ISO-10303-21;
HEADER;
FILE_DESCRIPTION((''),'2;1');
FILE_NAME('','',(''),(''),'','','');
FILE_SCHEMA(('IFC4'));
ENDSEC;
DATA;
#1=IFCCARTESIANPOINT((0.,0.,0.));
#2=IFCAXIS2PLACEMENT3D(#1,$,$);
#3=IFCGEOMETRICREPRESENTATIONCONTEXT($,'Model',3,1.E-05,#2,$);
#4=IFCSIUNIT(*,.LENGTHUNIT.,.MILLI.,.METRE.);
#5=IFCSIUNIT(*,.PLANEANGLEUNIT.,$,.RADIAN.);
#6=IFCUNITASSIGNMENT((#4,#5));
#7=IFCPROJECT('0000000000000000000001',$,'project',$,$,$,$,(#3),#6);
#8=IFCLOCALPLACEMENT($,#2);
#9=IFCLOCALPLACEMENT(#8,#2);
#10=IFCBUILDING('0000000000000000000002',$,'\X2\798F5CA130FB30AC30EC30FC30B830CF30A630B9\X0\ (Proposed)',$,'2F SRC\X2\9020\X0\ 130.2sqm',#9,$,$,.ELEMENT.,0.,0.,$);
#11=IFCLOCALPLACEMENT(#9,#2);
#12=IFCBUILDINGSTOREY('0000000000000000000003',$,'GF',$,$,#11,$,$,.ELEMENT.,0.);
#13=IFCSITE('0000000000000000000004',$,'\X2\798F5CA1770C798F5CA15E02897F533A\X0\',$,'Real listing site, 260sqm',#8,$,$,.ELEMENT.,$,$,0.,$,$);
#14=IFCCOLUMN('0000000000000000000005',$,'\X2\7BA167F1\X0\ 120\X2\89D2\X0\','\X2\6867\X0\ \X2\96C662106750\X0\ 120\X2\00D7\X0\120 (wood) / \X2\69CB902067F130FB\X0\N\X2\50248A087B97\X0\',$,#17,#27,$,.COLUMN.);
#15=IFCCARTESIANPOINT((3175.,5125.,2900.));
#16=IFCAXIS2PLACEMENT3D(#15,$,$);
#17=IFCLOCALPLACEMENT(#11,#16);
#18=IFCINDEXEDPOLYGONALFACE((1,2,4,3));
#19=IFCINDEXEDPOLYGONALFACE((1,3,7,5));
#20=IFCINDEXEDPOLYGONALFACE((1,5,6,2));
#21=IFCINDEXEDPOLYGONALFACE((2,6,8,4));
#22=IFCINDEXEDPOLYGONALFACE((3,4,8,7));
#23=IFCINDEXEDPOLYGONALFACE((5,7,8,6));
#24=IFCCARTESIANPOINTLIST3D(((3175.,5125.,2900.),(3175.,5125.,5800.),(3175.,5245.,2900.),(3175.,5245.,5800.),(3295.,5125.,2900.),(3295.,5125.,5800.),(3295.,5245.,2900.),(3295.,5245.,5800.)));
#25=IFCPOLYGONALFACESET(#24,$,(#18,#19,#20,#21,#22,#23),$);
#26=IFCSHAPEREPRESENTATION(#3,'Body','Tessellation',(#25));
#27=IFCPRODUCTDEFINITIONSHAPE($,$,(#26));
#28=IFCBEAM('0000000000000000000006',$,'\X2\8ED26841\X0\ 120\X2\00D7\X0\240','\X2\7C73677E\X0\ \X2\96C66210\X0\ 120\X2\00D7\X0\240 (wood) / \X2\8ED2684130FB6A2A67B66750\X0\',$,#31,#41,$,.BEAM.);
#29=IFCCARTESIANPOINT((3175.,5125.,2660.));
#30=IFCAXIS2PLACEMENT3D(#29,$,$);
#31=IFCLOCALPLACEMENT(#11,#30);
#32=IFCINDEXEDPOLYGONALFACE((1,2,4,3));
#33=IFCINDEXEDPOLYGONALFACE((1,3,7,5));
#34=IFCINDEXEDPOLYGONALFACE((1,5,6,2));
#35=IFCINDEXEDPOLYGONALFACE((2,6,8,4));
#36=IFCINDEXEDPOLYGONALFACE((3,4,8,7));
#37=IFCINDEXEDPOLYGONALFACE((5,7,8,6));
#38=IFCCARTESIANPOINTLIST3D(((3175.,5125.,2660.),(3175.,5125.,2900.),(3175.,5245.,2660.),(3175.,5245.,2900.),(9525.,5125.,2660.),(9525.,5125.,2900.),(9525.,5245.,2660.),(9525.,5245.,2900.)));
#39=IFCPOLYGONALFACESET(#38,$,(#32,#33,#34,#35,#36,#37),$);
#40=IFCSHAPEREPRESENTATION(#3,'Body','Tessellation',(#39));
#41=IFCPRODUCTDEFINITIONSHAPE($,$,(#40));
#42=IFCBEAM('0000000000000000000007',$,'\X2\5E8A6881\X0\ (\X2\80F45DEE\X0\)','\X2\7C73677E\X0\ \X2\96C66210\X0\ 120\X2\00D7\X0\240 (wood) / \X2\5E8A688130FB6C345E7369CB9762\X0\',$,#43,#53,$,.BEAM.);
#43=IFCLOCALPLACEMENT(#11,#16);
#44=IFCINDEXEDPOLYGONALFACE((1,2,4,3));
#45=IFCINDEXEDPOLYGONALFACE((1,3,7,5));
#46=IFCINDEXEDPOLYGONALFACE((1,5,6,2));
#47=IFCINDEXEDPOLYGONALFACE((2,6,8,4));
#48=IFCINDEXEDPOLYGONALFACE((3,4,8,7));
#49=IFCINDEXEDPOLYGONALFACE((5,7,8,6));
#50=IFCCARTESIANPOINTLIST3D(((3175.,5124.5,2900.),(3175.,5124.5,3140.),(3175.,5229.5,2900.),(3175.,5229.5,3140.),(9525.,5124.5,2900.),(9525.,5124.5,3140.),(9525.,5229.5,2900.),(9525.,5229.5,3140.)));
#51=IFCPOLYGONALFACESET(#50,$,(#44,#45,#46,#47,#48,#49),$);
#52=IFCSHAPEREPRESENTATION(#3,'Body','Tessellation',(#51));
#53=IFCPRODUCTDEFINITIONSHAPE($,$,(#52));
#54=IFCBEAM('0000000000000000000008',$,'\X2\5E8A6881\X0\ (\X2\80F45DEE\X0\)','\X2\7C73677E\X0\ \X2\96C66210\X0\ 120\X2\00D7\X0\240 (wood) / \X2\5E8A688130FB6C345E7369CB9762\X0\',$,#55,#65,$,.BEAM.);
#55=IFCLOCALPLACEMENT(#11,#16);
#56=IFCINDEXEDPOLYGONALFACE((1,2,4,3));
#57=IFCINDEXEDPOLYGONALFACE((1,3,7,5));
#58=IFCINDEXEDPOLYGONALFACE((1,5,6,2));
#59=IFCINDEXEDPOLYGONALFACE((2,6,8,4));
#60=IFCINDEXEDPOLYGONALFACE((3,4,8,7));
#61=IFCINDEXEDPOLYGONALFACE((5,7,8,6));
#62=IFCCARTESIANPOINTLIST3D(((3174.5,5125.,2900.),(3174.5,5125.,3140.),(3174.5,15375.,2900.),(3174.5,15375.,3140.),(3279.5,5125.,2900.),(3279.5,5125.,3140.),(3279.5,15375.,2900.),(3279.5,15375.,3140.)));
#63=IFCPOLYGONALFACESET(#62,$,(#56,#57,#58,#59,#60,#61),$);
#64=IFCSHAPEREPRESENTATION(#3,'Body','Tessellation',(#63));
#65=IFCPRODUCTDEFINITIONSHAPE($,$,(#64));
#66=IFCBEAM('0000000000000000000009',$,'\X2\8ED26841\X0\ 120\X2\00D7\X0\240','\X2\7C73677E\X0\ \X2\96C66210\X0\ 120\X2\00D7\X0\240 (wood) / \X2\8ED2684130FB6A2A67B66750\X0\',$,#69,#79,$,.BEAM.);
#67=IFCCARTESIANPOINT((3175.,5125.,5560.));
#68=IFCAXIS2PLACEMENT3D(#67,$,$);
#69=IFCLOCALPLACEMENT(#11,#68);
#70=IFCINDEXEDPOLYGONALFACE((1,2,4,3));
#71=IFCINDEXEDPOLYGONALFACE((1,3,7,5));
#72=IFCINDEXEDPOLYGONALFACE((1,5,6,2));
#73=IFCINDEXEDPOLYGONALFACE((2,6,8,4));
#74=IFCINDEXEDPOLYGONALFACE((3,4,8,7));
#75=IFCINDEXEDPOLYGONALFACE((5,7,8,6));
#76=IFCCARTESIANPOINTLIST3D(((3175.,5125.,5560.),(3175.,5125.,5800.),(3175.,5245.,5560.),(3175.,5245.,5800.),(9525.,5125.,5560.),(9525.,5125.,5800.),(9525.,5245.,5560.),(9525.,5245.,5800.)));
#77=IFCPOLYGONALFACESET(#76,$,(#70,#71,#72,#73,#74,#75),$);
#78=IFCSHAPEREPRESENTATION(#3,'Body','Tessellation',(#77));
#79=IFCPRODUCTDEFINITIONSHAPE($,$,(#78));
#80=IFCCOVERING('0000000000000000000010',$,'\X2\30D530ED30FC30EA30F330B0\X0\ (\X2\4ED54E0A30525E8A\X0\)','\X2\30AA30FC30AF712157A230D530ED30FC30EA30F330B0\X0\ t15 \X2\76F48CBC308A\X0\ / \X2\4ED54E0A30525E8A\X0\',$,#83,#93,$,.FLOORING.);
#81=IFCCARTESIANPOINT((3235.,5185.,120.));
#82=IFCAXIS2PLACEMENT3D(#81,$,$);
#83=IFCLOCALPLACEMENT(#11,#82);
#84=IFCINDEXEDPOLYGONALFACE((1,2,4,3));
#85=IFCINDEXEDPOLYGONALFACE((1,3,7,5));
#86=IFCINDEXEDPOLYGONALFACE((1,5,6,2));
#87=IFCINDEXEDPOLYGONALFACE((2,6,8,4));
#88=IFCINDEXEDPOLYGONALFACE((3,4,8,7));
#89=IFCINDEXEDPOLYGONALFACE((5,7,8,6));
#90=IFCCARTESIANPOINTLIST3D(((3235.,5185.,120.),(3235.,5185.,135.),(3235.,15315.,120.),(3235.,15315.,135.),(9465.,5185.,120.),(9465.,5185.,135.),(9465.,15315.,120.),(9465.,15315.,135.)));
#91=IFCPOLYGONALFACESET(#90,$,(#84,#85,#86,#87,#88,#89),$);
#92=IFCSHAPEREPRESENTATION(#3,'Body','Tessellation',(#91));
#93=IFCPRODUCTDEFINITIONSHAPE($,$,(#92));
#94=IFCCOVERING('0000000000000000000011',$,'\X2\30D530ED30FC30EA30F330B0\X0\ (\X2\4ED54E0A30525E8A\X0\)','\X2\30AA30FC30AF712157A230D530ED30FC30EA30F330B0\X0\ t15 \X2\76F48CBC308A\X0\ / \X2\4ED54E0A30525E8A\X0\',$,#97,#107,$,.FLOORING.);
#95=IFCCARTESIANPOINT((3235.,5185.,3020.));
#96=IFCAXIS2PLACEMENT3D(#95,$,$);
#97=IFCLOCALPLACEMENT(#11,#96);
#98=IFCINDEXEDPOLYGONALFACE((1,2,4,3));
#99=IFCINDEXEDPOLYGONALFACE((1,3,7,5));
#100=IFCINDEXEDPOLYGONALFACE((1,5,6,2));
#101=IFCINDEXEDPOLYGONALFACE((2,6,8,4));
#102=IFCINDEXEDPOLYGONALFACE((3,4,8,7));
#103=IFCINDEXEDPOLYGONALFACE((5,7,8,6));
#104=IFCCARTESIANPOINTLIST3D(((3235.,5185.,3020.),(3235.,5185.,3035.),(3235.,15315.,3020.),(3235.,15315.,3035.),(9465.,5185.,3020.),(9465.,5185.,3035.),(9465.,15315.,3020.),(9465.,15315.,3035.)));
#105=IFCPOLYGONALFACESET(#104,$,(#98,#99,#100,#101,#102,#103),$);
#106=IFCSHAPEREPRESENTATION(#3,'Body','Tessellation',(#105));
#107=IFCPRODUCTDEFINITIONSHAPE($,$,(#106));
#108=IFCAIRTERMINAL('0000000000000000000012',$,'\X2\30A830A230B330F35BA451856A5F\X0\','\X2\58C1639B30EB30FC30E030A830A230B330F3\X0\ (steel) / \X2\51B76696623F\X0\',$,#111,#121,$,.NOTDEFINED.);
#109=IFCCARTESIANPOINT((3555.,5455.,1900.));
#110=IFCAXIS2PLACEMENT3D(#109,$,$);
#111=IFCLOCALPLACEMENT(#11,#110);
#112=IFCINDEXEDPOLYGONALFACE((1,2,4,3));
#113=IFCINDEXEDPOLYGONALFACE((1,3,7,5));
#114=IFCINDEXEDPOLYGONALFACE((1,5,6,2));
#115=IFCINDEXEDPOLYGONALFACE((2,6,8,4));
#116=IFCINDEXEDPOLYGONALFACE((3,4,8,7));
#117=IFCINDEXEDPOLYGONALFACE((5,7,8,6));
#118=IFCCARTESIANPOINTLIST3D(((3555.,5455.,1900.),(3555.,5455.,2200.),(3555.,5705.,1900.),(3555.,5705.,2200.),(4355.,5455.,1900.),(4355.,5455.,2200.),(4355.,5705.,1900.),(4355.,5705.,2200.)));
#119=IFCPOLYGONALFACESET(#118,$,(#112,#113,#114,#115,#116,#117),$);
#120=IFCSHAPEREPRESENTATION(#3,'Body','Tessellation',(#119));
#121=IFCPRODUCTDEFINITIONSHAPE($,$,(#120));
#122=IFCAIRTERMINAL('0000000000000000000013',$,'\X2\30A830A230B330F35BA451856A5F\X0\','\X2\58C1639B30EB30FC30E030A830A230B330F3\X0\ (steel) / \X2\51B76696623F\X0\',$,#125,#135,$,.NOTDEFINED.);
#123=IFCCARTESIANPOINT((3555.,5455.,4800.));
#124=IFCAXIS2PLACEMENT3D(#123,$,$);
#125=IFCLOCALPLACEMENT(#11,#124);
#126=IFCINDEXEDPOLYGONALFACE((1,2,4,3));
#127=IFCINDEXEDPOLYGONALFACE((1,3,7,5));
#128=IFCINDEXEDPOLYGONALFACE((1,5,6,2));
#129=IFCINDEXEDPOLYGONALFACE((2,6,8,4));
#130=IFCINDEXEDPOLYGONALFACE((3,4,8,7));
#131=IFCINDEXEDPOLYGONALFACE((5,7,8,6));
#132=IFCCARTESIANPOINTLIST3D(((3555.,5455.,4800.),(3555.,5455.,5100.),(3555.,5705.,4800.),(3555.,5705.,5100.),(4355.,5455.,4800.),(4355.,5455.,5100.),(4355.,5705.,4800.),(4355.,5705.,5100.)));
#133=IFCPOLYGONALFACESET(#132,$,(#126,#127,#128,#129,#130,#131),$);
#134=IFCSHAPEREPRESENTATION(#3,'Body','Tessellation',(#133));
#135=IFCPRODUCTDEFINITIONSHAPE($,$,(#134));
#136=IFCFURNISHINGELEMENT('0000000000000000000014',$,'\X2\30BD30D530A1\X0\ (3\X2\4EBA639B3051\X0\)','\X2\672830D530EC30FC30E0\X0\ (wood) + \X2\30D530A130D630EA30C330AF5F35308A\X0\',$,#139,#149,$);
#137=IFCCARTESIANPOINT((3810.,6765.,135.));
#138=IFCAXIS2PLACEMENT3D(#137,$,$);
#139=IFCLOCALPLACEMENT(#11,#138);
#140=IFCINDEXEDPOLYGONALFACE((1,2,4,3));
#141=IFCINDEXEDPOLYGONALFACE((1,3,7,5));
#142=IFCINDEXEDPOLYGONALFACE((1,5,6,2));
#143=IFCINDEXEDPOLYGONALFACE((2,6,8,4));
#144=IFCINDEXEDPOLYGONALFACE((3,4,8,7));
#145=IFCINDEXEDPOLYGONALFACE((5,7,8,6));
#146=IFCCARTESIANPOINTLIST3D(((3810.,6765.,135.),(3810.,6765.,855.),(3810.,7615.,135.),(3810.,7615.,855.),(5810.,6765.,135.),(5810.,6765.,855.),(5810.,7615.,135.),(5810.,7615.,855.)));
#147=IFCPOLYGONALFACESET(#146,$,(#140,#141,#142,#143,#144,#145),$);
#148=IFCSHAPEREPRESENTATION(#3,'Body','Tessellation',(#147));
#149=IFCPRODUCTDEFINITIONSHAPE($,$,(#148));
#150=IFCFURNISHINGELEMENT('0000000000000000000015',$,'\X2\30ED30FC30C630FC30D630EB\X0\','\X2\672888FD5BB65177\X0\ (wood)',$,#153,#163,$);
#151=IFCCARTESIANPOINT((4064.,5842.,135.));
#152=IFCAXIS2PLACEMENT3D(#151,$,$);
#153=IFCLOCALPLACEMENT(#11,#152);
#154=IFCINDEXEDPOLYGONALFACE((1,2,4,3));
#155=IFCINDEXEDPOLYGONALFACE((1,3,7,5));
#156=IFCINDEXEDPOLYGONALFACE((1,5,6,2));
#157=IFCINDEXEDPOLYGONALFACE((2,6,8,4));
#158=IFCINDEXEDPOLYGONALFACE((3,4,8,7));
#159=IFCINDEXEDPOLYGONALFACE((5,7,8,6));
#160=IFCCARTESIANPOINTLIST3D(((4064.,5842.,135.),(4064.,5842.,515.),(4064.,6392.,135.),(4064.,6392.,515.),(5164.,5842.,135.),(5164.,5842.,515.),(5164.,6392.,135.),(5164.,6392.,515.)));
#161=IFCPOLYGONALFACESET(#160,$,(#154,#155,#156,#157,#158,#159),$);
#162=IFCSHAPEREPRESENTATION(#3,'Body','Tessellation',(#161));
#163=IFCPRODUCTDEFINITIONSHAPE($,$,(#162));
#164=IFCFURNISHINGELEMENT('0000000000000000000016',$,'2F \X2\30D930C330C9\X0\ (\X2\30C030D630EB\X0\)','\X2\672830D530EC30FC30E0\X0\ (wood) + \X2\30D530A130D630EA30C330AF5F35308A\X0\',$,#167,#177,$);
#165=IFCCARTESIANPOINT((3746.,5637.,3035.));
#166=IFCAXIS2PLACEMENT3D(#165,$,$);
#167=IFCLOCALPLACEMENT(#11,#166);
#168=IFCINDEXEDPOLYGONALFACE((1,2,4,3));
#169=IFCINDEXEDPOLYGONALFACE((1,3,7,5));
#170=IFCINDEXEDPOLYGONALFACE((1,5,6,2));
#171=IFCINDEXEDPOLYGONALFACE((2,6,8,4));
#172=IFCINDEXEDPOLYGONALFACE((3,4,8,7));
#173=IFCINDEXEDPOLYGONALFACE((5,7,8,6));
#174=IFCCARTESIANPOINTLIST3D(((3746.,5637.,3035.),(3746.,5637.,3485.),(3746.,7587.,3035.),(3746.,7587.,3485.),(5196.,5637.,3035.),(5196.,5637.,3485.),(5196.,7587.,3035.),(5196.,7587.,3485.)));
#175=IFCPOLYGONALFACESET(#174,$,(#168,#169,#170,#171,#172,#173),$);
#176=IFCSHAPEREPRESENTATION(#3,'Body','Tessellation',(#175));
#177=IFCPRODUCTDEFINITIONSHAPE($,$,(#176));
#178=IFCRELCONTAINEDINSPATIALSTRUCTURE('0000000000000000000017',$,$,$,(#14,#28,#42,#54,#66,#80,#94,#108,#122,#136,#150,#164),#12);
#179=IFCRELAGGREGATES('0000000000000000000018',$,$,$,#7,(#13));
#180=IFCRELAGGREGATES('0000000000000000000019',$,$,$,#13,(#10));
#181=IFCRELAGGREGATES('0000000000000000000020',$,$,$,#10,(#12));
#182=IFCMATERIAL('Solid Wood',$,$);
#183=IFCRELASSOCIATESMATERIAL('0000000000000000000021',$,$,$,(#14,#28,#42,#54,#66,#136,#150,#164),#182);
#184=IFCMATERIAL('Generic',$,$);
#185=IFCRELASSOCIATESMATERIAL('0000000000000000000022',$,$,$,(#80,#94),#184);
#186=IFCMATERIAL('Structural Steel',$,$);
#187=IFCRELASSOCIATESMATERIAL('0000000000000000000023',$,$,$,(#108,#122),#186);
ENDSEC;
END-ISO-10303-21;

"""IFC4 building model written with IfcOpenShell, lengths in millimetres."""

from ifc_helpers import new_model, si_unit, frame, frame_2d, origin, place, context, project, spatial, rectangle, extrude, material, element, save


model = new_model("IFC4")

# Units and contexts
model_context = context("Model", 3, precision=1e-05, world=origin())
ifc_project = project(units=[si_unit("LENGTHUNIT", "METRE", prefix="MILLI"), si_unit("PLANEANGLEUNIT", "RADIAN")], contexts=[model_context])

# Site, building, storey
site_placement = place(None, origin())
site = spatial("IfcSite", under=ifc_project, at=site_placement, Name="福岡県福岡市西区", ObjectType="Real listing site, 260sqm", CompositionType="ELEMENT", RefElevation=0.0)
building_placement = place(site_placement, origin())
building = spatial("IfcBuilding", under=site, at=building_placement, Name="福岡・ガレージハウス (Proposed)", ObjectType="2F SRC造 130.2sqm", CompositionType="ELEMENT", ElevationOfRefHeight=0.0, ElevationOfTerrain=0.0)
storey_placement = place(building_placement, origin())
storey = spatial("IfcBuildingStorey", under=building, at=storey_placement, Name="GF", CompositionType="ELEMENT", Elevation=0.0)

# Column
ifc_material_1 = material(Name="Solid Wood")
column_1_placement = place(storey_placement, frame((3175.0, 5125.0, 2900.0)))
element("IfcColumn", 1, at=column_1_placement, inside=storey, material=ifc_material_1, Name="管柱 120角", Description="桧 集成材 120×120 (wood) / 構造柱・N値計算", PredefinedType="COLUMN", context=model_context, shape_type="SweptSolid", body=[
    extrude(rectangle(XDim=120.0, YDim=120.0, at=frame_2d((60.0, 60.0))), frame((3175.0, 5125.0, 2900.0)), (0.0, 0.0, 1.0), 2900.0),
])

# Beams
beam_1_placement = place(storey_placement, frame((3175.0, 5125.0, 2660.0)))
element("IfcBeam", 2, at=beam_1_placement, inside=storey, material=ifc_material_1, Name="軒桁 120×240", Description="米松 集成 120×240 (wood) / 軒桁・横架材", PredefinedType="BEAM", context=model_context, shape_type="SweptSolid", body=[
    extrude(rectangle(XDim=6350.0, YDim=120.0, at=frame_2d((3175.0, 60.0))), frame((3175.0, 5125.0, 2660.0)), (0.0, 0.0, 1.0), 240.0),
])
beam_2_placement = place(storey_placement, frame((3175.0, 5125.0, 2900.0)))
element("IfcBeam", 3, at=beam_2_placement, inside=storey, material=ifc_material_1, Name="床梁 (胴差)", Description="米松 集成 120×240 (wood) / 床梁・水平構面", PredefinedType="BEAM", context=model_context, shape_type="SweptSolid", body=[
    extrude(rectangle(XDim=6350.0, YDim=105.0, at=frame_2d((3175.0, 52.0))), frame((3175.0, 5125.0, 2900.0)), (0.0, 0.0, 1.0), 240.0),
])
beam_3_placement = place(storey_placement, frame((3175.0, 5125.0, 2900.0)))
element("IfcBeam", 4, at=beam_3_placement, inside=storey, material=ifc_material_1, Name="床梁 (胴差)", Description="米松 集成 120×240 (wood) / 床梁・水平構面", PredefinedType="BEAM", context=model_context, shape_type="SweptSolid", body=[
    extrude(rectangle(XDim=105.0, YDim=10250.0, at=frame_2d((52.0, 5125.0))), frame((3175.0, 5125.0, 2900.0)), (0.0, 0.0, 1.0), 240.0),
])
beam_4_placement = place(storey_placement, frame((3175.0, 5125.0, 5560.0)))
element("IfcBeam", 5, at=beam_4_placement, inside=storey, material=ifc_material_1, Name="軒桁 120×240", Description="米松 集成 120×240 (wood) / 軒桁・横架材", PredefinedType="BEAM", context=model_context, shape_type="SweptSolid", body=[
    extrude(rectangle(XDim=6350.0, YDim=120.0, at=frame_2d((3175.0, 60.0))), frame((3175.0, 5125.0, 5560.0)), (0.0, 0.0, 1.0), 240.0),
])

# Coverings
ifc_material_2 = material(Name="Generic")
covering_1_placement = place(storey_placement, frame((3235.0, 5185.0, 120.0)))
element("IfcCovering", 6, at=covering_1_placement, inside=storey, material=ifc_material_2, Name="フローリング (仕上げ床)", Description="オーク無垢フローリング t15 直貼り / 仕上げ床", PredefinedType="FLOORING", context=model_context, shape_type="SweptSolid", body=[
    extrude(rectangle(XDim=6230.0, YDim=10130.0, at=frame_2d((3115.0, 5065.0))), frame((3235.0, 5185.0, 120.0)), (0.0, 0.0, 1.0), 15.0),
])
covering_2_placement = place(storey_placement, frame((3235.0, 5185.0, 3020.0)))
element("IfcCovering", 7, at=covering_2_placement, inside=storey, material=ifc_material_2, Name="フローリング (仕上げ床)", Description="オーク無垢フローリング t15 直貼り / 仕上げ床", PredefinedType="FLOORING", context=model_context, shape_type="SweptSolid", body=[
    extrude(rectangle(XDim=6230.0, YDim=10130.0, at=frame_2d((3115.0, 5065.0))), frame((3235.0, 5185.0, 3020.0)), (0.0, 0.0, 1.0), 15.0),
])

# Air terminals
ifc_material_3 = material(Name="Structural Steel")
air_terminal_1_placement = place(storey_placement, frame((3555.0, 5455.0, 1900.0)))
element("IfcAirTerminal", 8, at=air_terminal_1_placement, inside=storey, material=ifc_material_3, Name="エアコン室内機", Description="壁掛ルームエアコン (steel) / 冷暖房", PredefinedType="NOTDEFINED", context=model_context, shape_type="SweptSolid", body=[
    extrude(rectangle(XDim=800.0, YDim=250.0, at=frame_2d((400.0, 125.0))), frame((3555.0, 5455.0, 1900.0)), (0.0, 0.0, 1.0), 300.0),
])
air_terminal_2_placement = place(storey_placement, frame((3555.0, 5455.0, 4800.0)))
element("IfcAirTerminal", 9, at=air_terminal_2_placement, inside=storey, material=ifc_material_3, Name="エアコン室内機", Description="壁掛ルームエアコン (steel) / 冷暖房", PredefinedType="NOTDEFINED", context=model_context, shape_type="SweptSolid", body=[
    extrude(rectangle(XDim=800.0, YDim=250.0, at=frame_2d((400.0, 125.0))), frame((3555.0, 5455.0, 4800.0)), (0.0, 0.0, 1.0), 300.0),
])

# Furnishing elements
furnishing_1_placement = place(storey_placement, frame((3810.0, 6765.0, 135.0)))
element("IfcFurnishingElement", 10, at=furnishing_1_placement, inside=storey, material=ifc_material_1, Name="ソファ (3人掛け)", Description="木フレーム (wood) + ファブリック張り", context=model_context, shape_type="SweptSolid", body=[
    extrude(rectangle(XDim=2000.0, YDim=850.0, at=frame_2d((1000.0, 425.0))), frame((3810.0, 6765.0, 135.0)), (0.0, 0.0, 1.0), 720.0),
])
furnishing_2_placement = place(storey_placement, frame((4064.0, 5842.0, 135.0)))
element("IfcFurnishingElement", 11, at=furnishing_2_placement, inside=storey, material=ifc_material_1, Name="ローテーブル", Description="木製家具 (wood)", context=model_context, shape_type="SweptSolid", body=[
    extrude(rectangle(XDim=1100.0, YDim=550.0, at=frame_2d((550.0, 275.0))), frame((4064.0, 5842.0, 135.0)), (0.0, 0.0, 1.0), 380.0),
])
furnishing_3_placement = place(storey_placement, frame((3746.0, 5637.0, 3035.0)))
element("IfcFurnishingElement", 12, at=furnishing_3_placement, inside=storey, material=ifc_material_1, Name="2F ベッド (ダブル)", Description="木フレーム (wood) + ファブリック張り", context=model_context, shape_type="SweptSolid", body=[
    extrude(rectangle(XDim=1450.0, YDim=1950.0, at=frame_2d((725.0, 975.0))), frame((3746.0, 5637.0, 3035.0)), (0.0, 0.0, 1.0), 450.0),
])

save(model, "model.ifc")
